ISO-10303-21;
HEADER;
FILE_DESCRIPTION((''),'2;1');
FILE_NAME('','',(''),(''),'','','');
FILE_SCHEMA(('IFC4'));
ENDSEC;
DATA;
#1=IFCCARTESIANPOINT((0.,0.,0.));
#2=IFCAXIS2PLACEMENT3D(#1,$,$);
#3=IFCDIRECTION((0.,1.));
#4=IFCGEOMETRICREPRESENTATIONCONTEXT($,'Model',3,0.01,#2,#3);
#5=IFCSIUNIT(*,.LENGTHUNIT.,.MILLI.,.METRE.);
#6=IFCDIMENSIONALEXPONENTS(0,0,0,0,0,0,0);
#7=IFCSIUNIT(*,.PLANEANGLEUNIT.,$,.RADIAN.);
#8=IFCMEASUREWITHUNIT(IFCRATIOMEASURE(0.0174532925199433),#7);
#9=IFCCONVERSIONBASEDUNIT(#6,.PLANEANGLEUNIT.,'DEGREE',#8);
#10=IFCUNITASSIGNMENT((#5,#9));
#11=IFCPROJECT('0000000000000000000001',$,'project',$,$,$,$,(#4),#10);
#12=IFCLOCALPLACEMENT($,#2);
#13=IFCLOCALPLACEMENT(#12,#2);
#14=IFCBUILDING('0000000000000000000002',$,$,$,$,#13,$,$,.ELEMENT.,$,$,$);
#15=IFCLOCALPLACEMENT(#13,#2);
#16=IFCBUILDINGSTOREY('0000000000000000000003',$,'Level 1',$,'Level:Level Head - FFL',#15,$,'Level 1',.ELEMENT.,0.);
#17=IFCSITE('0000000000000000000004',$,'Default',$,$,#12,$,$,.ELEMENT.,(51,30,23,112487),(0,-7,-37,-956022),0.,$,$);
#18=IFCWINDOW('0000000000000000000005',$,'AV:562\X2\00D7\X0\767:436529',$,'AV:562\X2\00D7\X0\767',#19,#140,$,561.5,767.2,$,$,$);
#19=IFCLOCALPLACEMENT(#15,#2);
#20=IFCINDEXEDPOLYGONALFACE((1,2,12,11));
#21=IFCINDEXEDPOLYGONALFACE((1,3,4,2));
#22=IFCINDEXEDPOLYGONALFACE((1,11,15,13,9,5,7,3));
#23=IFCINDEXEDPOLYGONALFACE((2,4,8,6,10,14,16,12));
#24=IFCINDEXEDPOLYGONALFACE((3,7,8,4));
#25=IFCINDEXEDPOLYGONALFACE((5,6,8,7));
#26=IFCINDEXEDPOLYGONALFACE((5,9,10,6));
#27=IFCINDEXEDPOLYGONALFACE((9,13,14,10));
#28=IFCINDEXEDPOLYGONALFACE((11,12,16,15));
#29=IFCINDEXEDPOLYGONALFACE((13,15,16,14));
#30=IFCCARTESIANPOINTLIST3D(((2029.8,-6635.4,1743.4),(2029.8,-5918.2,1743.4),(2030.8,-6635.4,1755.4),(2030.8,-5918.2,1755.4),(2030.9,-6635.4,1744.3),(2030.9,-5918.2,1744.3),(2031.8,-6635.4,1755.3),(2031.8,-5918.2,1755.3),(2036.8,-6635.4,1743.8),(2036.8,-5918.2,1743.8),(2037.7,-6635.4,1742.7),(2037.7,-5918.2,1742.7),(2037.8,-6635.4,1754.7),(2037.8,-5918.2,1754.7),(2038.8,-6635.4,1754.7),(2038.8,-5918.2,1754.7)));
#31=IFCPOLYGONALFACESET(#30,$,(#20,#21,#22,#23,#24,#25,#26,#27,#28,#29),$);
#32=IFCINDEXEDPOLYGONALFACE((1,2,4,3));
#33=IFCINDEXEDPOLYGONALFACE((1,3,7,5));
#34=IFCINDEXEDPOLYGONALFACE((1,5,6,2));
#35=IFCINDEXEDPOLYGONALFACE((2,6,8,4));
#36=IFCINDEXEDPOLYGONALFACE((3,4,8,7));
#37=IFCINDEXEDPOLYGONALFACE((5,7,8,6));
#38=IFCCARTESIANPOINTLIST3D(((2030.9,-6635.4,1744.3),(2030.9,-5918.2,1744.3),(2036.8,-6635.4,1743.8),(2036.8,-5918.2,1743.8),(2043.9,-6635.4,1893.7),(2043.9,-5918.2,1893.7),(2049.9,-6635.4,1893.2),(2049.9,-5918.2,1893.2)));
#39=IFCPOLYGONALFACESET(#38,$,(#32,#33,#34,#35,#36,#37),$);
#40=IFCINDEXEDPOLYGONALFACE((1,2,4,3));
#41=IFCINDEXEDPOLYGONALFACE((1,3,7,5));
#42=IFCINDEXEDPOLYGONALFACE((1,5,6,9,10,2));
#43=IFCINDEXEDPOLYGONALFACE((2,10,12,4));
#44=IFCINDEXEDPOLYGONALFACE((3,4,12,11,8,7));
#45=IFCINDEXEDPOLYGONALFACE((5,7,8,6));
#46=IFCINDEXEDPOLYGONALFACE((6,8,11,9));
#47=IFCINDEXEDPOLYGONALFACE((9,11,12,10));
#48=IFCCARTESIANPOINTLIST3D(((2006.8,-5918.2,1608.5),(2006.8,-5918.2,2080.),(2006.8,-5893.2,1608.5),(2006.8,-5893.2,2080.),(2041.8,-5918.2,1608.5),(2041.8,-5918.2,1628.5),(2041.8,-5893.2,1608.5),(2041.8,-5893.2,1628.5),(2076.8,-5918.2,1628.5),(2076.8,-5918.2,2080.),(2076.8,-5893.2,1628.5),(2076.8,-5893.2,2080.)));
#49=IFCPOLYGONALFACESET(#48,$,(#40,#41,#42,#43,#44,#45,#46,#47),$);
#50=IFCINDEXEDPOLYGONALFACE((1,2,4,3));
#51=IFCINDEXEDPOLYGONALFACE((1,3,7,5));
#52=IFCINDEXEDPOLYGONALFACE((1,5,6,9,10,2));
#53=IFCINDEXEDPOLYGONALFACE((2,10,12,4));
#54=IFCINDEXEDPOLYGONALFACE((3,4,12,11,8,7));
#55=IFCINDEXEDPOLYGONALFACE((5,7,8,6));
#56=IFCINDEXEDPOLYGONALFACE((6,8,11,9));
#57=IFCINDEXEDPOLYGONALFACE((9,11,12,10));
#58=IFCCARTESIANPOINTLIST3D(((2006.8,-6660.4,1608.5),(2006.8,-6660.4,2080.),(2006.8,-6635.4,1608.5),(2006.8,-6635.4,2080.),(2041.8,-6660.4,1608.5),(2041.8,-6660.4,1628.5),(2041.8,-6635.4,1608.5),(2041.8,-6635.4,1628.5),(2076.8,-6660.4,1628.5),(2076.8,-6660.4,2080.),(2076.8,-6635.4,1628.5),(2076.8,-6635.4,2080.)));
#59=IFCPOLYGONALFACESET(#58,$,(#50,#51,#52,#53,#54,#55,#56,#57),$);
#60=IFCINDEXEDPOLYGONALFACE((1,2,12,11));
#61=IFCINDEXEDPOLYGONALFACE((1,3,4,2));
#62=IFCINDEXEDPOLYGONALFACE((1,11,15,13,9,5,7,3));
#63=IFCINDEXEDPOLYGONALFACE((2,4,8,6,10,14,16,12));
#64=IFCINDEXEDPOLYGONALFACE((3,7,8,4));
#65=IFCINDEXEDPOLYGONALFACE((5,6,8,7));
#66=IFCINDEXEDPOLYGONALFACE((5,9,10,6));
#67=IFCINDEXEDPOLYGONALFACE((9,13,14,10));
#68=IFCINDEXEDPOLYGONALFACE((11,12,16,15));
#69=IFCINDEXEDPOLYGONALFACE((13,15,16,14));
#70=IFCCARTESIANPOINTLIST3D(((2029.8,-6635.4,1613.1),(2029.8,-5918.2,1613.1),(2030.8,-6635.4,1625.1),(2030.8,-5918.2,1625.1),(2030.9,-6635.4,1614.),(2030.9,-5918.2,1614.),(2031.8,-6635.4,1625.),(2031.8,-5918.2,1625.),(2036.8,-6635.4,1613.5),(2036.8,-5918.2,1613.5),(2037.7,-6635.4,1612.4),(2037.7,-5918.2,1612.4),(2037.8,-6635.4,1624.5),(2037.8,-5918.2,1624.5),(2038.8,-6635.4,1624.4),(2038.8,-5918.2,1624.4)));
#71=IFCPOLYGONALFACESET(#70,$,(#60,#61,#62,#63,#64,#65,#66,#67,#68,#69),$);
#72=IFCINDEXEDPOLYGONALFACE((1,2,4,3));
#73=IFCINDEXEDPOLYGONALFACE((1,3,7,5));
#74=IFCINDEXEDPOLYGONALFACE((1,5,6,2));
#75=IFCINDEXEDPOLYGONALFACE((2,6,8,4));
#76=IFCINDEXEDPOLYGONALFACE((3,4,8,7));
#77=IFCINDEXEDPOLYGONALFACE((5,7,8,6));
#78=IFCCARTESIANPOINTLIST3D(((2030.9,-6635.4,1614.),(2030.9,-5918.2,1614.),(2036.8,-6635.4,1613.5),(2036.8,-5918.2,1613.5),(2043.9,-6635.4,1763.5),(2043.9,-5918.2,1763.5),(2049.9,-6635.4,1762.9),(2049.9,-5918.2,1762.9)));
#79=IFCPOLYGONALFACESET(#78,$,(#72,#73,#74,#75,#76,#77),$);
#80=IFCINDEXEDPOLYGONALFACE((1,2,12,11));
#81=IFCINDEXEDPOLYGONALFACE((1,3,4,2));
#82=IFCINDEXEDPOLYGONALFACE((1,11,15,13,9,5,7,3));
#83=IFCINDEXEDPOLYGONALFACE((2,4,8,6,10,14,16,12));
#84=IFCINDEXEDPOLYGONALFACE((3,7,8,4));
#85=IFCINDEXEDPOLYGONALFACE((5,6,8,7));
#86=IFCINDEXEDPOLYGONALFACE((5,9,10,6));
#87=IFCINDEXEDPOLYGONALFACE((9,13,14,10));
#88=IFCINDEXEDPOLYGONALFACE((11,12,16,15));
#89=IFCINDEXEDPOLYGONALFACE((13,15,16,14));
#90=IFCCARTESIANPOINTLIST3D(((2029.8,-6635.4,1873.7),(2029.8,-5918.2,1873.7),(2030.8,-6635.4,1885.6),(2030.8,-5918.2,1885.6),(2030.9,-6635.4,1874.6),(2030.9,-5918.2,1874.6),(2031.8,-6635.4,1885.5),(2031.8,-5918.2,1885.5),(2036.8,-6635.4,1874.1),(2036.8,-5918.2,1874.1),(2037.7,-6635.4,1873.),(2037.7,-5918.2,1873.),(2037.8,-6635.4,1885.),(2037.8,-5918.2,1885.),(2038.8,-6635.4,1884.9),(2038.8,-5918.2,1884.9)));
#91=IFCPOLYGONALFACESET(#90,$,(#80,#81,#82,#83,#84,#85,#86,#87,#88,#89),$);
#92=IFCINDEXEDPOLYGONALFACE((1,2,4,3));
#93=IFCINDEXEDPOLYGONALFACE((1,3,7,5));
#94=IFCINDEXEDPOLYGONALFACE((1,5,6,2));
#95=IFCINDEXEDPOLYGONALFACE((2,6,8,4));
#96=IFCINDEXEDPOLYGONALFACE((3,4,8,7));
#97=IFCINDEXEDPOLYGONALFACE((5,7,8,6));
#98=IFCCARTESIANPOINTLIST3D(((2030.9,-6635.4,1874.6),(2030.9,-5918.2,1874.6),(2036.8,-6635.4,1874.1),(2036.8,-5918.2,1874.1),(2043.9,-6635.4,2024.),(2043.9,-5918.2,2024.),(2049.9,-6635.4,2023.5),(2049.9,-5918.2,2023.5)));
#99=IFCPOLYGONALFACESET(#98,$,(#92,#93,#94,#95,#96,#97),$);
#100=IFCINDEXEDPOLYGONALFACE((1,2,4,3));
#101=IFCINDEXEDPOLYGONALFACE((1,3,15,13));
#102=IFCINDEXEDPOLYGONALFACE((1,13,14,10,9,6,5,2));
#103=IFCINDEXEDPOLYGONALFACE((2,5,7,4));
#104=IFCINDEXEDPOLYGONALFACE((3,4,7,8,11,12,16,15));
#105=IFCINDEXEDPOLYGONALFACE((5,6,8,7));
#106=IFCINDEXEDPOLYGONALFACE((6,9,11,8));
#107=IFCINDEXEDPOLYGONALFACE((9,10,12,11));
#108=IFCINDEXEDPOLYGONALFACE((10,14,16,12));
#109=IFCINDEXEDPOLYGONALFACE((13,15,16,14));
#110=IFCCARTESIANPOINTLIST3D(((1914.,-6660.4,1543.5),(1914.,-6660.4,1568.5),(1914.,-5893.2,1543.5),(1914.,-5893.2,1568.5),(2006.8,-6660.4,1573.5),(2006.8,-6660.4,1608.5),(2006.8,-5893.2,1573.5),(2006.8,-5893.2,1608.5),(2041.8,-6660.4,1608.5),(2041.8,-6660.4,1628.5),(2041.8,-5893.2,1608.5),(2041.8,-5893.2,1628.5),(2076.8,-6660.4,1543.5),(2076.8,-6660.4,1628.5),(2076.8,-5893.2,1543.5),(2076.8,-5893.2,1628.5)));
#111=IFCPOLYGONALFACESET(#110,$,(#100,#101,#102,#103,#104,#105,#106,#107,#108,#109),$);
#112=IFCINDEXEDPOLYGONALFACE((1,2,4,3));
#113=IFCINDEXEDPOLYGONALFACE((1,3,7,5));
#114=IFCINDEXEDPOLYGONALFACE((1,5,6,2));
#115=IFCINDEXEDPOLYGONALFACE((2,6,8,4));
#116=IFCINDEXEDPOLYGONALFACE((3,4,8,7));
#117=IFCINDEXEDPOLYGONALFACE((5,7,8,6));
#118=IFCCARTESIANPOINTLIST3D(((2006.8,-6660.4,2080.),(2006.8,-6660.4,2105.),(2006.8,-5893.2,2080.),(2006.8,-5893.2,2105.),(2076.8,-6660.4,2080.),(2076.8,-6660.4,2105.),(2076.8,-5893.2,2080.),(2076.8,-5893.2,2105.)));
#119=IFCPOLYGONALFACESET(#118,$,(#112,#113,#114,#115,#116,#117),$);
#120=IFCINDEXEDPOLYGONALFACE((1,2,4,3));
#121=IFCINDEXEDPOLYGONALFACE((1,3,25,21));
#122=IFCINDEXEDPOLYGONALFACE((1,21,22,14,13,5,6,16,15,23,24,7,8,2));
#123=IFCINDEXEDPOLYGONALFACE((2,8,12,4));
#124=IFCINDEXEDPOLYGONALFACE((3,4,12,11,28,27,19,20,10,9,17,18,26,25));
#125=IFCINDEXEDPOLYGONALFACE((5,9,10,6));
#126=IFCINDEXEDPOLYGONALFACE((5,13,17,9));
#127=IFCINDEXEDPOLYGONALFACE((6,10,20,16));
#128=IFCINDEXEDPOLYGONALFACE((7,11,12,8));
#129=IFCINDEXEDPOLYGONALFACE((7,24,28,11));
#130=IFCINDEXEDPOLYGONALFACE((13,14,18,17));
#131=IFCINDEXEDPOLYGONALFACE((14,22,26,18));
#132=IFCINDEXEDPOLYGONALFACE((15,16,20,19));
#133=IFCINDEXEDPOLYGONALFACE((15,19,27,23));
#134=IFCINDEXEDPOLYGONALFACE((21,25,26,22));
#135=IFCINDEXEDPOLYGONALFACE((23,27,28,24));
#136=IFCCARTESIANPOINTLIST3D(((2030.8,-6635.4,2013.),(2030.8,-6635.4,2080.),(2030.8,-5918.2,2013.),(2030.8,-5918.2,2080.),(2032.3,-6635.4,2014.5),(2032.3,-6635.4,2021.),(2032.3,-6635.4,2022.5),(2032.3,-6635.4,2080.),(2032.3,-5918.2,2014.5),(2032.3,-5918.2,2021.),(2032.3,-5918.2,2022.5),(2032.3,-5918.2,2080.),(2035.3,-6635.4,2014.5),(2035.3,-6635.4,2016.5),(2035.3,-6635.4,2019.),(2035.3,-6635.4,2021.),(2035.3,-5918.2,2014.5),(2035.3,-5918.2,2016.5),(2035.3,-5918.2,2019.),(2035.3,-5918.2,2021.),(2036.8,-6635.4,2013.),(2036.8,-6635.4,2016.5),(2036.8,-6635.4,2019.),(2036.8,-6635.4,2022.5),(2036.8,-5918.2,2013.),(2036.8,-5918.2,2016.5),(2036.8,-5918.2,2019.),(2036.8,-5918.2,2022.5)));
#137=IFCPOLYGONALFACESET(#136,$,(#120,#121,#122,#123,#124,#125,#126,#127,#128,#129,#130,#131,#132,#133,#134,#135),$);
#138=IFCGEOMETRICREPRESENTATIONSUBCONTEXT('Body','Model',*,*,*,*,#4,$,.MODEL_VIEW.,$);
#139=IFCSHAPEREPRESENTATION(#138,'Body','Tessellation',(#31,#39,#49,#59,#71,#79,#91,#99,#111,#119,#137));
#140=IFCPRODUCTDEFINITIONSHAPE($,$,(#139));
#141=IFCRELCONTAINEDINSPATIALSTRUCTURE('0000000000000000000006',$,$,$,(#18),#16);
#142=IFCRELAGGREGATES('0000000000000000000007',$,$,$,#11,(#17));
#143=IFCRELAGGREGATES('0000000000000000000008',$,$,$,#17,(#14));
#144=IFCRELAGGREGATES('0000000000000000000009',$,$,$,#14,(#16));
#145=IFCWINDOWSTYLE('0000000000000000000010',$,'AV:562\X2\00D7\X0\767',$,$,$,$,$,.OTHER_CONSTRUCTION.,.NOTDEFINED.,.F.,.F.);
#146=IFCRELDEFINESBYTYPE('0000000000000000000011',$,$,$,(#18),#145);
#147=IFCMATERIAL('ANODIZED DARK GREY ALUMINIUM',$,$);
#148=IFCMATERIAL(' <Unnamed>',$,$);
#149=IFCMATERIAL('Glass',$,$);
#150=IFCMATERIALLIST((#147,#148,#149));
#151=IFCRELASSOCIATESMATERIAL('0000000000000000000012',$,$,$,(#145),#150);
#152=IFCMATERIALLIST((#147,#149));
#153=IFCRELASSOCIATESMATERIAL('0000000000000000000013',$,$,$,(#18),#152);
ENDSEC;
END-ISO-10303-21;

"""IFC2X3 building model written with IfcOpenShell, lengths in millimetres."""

from ifc_helpers import new_model, entity, si_unit, converted_unit, direction, frame, frame_2d, origin, origin_2d_with_axis, place, context, subcontext, project, spatial, polyline, rectangle, outline, extrude, source, transform, mapped, material, material_list, type_object, type_shapes, element, save


model = new_model("IFC2X3")

# Units and contexts
model_context = context("Model", 3, precision=0.01, world=origin(), true_north=direction((0.0, 1.0)))
body_context = subcontext(model_context, "Body", "Model", "MODEL_VIEW")
ifc_project = project(units=[si_unit("LENGTHUNIT", "METRE", prefix="MILLI"), converted_unit("PLANEANGLEUNIT", "DEGREE", entity("IfcRatioMeasure", 0.0174532925199433), si_unit("PLANEANGLEUNIT", "RADIAN"), dimensions=[0, 0, 0, 0, 0, 0, 0])], contexts=[model_context])

# Site, building, storey
site_placement = place(None, origin())
site = spatial("IfcSite", under=ifc_project, at=site_placement, Name="Default", CompositionType="ELEMENT", RefLatitude=(51, 30, 23, 112487), RefLongitude=(0, -7, -37, -956022), RefElevation=0.0)
building_placement = place(site_placement, origin())
building = spatial("IfcBuilding", under=site, at=building_placement, CompositionType="ELEMENT")
storey_placement = place(building_placement, origin())
storey = spatial("IfcBuildingStorey", under=building, at=storey_placement, Name="Level 1", ObjectType="Level:Level Head - FFL", LongName="Level 1", CompositionType="ELEMENT", Elevation=0.0)

# Window
ifc_material_1 = material(Name="ANODIZED DARK GREY ALUMINIUM")
ifc_material_2 = material(Name="Glass")
ifc_material_list_1 = material_list([ifc_material_1, ifc_material_2])
ifc_material_3 = material(Name=" <Unnamed>")
ifc_material_list_2 = material_list([ifc_material_1, ifc_material_3, ifc_material_2])
window_style_1 = type_object("IfcWindowStyle", Name="AV:562×767", ConstructionType="OTHER_CONSTRUCTION", OperationType="NOTDEFINED", ParameterTakesPrecedence=False, Sizeable=False, material=ifc_material_list_2)
shared_shape_1 = source(origin(), body_context, "Body", "SweptSolid", [
    extrude(outline(polyline([(-5.8, -3.0), (-5.8, -4.0), (6.3, -4.0), (6.3, 4.0), (-5.8, 4.0), (-5.8, 3.0), (5.2, 3.0), (5.2, -3.0), (-5.8, -3.0)])), frame((25.0, 42.5, 205.8), z_axis=(-1.0, 0.0, 0.0), x_axis=(0.0, 0.087156, -0.996195)), (0.0, 0.0, -1.0), 717.2),
    extrude(rectangle(XDim=150.0, YDim=6.0, at=frame_2d((0.0, 0.0), x_axis=(1.0, 0.0))), frame((25.0, 36.5, 275.2), z_axis=(1.0, 0.0, 0.0), x_axis=(0.0, 0.087156, -0.996195)), (0.0, 0.0, 1.0), 717.2),
    extrude(outline(polyline([(-307.7, -35.0), (143.8, -35.0), (143.8, 0.0), (163.8, 0.0), (163.8, 35.0), (-307.7, 35.0), (-307.7, -35.0)])), frame((742.2, 35.0, 228.8), z_axis=(1.0, 0.0, 0.0), x_axis=(0.0, 0.0, -1.0)), (0.0, 0.0, 1.0), 25.0),
    extrude(outline(polyline([(-307.7, -35.0), (143.8, -35.0), (143.8, 0.0), (163.8, 0.0), (163.8, 35.0), (-307.7, 35.0), (-307.7, -35.0)])), frame((0.0, 35.0, 228.8), z_axis=(1.0, 0.0, 0.0), x_axis=(0.0, 0.0, -1.0)), (0.0, 0.0, 1.0), 25.0),
    extrude(outline(polyline([(-5.8, -3.0), (-5.8, -4.0), (6.3, -4.0), (6.3, 4.0), (-5.8, 4.0), (-5.8, 3.0), (5.2, 3.0), (5.2, -3.0), (-5.8, -3.0)])), frame((25.0, 42.5, 75.5), z_axis=(-1.0, 0.0, 0.0), x_axis=(0.0, 0.087156, -0.996195)), (0.0, 0.0, -1.0), 717.2),
    extrude(rectangle(XDim=150.0, YDim=6.0, at=frame_2d((0.0, 0.0), x_axis=(1.0, 0.0))), frame((25.0, 36.5, 145.0), z_axis=(1.0, 0.0, 0.0), x_axis=(0.0, 0.087156, -0.996195)), (0.0, 0.0, 1.0), 717.2),
    extrude(outline(polyline([(-5.8, -3.0), (-5.8, -4.0), (6.3, -4.0), (6.3, 4.0), (-5.8, 4.0), (-5.8, 3.0), (5.2, 3.0), (5.2, -3.0), (-5.8, -3.0)])), frame((25.0, 42.5, 336.0), z_axis=(-1.0, 0.0, 0.0), x_axis=(0.0, 0.087156, -0.996195)), (0.0, 0.0, -1.0), 717.2),
    extrude(rectangle(XDim=150.0, YDim=6.0, at=frame_2d((0.0, 0.0), x_axis=(1.0, 0.0))), frame((25.0, 36.5, 405.5), z_axis=(1.0, 0.0, 0.0), x_axis=(0.0, 0.087156, -0.996195)), (0.0, 0.0, 1.0), 717.2),
    extrude(outline(polyline([(-67.0, -44.4), (95.9, -44.4), (95.9, -19.4), (3.0, -14.4), (3.0, 20.6), (-32.0, 20.6), (-32.0, 40.6), (-67.0, 40.6), (-67.0, -44.4)])), frame((0.0, 67.0, 44.4), z_axis=(1.0, 0.0, 0.0), x_axis=(0.0, 1.0, 0.0)), (0.0, 0.0, 1.0), 767.2),
    extrude(rectangle(XDim=70.0, YDim=767.2, at=origin_2d_with_axis()), frame((383.6, 35.0, 536.5), z_axis=(0.0, 0.0, 1.0), x_axis=(0.0, -1.0, 0.0)), (0.0, 0.0, 1.0), 25.0),
    extrude(outline(polyline([(-3.4, -53.4), (-1.9, -53.4), (-1.9, 4.1), (2.6, 4.1), (2.6, 7.6), (1.1, 7.6), (1.1, 5.6), (-1.9, 5.6), (-1.9, 12.1), (1.1, 12.1), (1.1, 10.1), (2.6, 10.1), (2.6, 13.6), (-3.4, 13.6), (-3.4, -53.4)])), frame((25.0, 42.6, 483.2), z_axis=(1.0, 0.0, 0.0), x_axis=(0.0, -1.0, 0.0)), (0.0, 0.0, 1.0), 717.2),
])
type_shapes(window_style_1, [shared_shape_1])
window_1_placement = place(storey_placement, frame((2076.8, -6660.4, 1543.5), z_axis=(0.0, 0.0, 1.0), x_axis=(0.0, 1.0, 0.0)))
element("IfcWindow", 1, at=window_1_placement, inside=storey, type_object=window_style_1, material=ifc_material_list_1, Name="AV:562×767:436529", ObjectType="AV:562×767", OverallHeight=561.5, OverallWidth=767.2, context=body_context, shape_type="MappedRepresentation", body=[
    mapped(shared_shape_1, transform((0.0, 0.0, 0.0), scale=1.0)),
])

save(model, "model.ifc")
